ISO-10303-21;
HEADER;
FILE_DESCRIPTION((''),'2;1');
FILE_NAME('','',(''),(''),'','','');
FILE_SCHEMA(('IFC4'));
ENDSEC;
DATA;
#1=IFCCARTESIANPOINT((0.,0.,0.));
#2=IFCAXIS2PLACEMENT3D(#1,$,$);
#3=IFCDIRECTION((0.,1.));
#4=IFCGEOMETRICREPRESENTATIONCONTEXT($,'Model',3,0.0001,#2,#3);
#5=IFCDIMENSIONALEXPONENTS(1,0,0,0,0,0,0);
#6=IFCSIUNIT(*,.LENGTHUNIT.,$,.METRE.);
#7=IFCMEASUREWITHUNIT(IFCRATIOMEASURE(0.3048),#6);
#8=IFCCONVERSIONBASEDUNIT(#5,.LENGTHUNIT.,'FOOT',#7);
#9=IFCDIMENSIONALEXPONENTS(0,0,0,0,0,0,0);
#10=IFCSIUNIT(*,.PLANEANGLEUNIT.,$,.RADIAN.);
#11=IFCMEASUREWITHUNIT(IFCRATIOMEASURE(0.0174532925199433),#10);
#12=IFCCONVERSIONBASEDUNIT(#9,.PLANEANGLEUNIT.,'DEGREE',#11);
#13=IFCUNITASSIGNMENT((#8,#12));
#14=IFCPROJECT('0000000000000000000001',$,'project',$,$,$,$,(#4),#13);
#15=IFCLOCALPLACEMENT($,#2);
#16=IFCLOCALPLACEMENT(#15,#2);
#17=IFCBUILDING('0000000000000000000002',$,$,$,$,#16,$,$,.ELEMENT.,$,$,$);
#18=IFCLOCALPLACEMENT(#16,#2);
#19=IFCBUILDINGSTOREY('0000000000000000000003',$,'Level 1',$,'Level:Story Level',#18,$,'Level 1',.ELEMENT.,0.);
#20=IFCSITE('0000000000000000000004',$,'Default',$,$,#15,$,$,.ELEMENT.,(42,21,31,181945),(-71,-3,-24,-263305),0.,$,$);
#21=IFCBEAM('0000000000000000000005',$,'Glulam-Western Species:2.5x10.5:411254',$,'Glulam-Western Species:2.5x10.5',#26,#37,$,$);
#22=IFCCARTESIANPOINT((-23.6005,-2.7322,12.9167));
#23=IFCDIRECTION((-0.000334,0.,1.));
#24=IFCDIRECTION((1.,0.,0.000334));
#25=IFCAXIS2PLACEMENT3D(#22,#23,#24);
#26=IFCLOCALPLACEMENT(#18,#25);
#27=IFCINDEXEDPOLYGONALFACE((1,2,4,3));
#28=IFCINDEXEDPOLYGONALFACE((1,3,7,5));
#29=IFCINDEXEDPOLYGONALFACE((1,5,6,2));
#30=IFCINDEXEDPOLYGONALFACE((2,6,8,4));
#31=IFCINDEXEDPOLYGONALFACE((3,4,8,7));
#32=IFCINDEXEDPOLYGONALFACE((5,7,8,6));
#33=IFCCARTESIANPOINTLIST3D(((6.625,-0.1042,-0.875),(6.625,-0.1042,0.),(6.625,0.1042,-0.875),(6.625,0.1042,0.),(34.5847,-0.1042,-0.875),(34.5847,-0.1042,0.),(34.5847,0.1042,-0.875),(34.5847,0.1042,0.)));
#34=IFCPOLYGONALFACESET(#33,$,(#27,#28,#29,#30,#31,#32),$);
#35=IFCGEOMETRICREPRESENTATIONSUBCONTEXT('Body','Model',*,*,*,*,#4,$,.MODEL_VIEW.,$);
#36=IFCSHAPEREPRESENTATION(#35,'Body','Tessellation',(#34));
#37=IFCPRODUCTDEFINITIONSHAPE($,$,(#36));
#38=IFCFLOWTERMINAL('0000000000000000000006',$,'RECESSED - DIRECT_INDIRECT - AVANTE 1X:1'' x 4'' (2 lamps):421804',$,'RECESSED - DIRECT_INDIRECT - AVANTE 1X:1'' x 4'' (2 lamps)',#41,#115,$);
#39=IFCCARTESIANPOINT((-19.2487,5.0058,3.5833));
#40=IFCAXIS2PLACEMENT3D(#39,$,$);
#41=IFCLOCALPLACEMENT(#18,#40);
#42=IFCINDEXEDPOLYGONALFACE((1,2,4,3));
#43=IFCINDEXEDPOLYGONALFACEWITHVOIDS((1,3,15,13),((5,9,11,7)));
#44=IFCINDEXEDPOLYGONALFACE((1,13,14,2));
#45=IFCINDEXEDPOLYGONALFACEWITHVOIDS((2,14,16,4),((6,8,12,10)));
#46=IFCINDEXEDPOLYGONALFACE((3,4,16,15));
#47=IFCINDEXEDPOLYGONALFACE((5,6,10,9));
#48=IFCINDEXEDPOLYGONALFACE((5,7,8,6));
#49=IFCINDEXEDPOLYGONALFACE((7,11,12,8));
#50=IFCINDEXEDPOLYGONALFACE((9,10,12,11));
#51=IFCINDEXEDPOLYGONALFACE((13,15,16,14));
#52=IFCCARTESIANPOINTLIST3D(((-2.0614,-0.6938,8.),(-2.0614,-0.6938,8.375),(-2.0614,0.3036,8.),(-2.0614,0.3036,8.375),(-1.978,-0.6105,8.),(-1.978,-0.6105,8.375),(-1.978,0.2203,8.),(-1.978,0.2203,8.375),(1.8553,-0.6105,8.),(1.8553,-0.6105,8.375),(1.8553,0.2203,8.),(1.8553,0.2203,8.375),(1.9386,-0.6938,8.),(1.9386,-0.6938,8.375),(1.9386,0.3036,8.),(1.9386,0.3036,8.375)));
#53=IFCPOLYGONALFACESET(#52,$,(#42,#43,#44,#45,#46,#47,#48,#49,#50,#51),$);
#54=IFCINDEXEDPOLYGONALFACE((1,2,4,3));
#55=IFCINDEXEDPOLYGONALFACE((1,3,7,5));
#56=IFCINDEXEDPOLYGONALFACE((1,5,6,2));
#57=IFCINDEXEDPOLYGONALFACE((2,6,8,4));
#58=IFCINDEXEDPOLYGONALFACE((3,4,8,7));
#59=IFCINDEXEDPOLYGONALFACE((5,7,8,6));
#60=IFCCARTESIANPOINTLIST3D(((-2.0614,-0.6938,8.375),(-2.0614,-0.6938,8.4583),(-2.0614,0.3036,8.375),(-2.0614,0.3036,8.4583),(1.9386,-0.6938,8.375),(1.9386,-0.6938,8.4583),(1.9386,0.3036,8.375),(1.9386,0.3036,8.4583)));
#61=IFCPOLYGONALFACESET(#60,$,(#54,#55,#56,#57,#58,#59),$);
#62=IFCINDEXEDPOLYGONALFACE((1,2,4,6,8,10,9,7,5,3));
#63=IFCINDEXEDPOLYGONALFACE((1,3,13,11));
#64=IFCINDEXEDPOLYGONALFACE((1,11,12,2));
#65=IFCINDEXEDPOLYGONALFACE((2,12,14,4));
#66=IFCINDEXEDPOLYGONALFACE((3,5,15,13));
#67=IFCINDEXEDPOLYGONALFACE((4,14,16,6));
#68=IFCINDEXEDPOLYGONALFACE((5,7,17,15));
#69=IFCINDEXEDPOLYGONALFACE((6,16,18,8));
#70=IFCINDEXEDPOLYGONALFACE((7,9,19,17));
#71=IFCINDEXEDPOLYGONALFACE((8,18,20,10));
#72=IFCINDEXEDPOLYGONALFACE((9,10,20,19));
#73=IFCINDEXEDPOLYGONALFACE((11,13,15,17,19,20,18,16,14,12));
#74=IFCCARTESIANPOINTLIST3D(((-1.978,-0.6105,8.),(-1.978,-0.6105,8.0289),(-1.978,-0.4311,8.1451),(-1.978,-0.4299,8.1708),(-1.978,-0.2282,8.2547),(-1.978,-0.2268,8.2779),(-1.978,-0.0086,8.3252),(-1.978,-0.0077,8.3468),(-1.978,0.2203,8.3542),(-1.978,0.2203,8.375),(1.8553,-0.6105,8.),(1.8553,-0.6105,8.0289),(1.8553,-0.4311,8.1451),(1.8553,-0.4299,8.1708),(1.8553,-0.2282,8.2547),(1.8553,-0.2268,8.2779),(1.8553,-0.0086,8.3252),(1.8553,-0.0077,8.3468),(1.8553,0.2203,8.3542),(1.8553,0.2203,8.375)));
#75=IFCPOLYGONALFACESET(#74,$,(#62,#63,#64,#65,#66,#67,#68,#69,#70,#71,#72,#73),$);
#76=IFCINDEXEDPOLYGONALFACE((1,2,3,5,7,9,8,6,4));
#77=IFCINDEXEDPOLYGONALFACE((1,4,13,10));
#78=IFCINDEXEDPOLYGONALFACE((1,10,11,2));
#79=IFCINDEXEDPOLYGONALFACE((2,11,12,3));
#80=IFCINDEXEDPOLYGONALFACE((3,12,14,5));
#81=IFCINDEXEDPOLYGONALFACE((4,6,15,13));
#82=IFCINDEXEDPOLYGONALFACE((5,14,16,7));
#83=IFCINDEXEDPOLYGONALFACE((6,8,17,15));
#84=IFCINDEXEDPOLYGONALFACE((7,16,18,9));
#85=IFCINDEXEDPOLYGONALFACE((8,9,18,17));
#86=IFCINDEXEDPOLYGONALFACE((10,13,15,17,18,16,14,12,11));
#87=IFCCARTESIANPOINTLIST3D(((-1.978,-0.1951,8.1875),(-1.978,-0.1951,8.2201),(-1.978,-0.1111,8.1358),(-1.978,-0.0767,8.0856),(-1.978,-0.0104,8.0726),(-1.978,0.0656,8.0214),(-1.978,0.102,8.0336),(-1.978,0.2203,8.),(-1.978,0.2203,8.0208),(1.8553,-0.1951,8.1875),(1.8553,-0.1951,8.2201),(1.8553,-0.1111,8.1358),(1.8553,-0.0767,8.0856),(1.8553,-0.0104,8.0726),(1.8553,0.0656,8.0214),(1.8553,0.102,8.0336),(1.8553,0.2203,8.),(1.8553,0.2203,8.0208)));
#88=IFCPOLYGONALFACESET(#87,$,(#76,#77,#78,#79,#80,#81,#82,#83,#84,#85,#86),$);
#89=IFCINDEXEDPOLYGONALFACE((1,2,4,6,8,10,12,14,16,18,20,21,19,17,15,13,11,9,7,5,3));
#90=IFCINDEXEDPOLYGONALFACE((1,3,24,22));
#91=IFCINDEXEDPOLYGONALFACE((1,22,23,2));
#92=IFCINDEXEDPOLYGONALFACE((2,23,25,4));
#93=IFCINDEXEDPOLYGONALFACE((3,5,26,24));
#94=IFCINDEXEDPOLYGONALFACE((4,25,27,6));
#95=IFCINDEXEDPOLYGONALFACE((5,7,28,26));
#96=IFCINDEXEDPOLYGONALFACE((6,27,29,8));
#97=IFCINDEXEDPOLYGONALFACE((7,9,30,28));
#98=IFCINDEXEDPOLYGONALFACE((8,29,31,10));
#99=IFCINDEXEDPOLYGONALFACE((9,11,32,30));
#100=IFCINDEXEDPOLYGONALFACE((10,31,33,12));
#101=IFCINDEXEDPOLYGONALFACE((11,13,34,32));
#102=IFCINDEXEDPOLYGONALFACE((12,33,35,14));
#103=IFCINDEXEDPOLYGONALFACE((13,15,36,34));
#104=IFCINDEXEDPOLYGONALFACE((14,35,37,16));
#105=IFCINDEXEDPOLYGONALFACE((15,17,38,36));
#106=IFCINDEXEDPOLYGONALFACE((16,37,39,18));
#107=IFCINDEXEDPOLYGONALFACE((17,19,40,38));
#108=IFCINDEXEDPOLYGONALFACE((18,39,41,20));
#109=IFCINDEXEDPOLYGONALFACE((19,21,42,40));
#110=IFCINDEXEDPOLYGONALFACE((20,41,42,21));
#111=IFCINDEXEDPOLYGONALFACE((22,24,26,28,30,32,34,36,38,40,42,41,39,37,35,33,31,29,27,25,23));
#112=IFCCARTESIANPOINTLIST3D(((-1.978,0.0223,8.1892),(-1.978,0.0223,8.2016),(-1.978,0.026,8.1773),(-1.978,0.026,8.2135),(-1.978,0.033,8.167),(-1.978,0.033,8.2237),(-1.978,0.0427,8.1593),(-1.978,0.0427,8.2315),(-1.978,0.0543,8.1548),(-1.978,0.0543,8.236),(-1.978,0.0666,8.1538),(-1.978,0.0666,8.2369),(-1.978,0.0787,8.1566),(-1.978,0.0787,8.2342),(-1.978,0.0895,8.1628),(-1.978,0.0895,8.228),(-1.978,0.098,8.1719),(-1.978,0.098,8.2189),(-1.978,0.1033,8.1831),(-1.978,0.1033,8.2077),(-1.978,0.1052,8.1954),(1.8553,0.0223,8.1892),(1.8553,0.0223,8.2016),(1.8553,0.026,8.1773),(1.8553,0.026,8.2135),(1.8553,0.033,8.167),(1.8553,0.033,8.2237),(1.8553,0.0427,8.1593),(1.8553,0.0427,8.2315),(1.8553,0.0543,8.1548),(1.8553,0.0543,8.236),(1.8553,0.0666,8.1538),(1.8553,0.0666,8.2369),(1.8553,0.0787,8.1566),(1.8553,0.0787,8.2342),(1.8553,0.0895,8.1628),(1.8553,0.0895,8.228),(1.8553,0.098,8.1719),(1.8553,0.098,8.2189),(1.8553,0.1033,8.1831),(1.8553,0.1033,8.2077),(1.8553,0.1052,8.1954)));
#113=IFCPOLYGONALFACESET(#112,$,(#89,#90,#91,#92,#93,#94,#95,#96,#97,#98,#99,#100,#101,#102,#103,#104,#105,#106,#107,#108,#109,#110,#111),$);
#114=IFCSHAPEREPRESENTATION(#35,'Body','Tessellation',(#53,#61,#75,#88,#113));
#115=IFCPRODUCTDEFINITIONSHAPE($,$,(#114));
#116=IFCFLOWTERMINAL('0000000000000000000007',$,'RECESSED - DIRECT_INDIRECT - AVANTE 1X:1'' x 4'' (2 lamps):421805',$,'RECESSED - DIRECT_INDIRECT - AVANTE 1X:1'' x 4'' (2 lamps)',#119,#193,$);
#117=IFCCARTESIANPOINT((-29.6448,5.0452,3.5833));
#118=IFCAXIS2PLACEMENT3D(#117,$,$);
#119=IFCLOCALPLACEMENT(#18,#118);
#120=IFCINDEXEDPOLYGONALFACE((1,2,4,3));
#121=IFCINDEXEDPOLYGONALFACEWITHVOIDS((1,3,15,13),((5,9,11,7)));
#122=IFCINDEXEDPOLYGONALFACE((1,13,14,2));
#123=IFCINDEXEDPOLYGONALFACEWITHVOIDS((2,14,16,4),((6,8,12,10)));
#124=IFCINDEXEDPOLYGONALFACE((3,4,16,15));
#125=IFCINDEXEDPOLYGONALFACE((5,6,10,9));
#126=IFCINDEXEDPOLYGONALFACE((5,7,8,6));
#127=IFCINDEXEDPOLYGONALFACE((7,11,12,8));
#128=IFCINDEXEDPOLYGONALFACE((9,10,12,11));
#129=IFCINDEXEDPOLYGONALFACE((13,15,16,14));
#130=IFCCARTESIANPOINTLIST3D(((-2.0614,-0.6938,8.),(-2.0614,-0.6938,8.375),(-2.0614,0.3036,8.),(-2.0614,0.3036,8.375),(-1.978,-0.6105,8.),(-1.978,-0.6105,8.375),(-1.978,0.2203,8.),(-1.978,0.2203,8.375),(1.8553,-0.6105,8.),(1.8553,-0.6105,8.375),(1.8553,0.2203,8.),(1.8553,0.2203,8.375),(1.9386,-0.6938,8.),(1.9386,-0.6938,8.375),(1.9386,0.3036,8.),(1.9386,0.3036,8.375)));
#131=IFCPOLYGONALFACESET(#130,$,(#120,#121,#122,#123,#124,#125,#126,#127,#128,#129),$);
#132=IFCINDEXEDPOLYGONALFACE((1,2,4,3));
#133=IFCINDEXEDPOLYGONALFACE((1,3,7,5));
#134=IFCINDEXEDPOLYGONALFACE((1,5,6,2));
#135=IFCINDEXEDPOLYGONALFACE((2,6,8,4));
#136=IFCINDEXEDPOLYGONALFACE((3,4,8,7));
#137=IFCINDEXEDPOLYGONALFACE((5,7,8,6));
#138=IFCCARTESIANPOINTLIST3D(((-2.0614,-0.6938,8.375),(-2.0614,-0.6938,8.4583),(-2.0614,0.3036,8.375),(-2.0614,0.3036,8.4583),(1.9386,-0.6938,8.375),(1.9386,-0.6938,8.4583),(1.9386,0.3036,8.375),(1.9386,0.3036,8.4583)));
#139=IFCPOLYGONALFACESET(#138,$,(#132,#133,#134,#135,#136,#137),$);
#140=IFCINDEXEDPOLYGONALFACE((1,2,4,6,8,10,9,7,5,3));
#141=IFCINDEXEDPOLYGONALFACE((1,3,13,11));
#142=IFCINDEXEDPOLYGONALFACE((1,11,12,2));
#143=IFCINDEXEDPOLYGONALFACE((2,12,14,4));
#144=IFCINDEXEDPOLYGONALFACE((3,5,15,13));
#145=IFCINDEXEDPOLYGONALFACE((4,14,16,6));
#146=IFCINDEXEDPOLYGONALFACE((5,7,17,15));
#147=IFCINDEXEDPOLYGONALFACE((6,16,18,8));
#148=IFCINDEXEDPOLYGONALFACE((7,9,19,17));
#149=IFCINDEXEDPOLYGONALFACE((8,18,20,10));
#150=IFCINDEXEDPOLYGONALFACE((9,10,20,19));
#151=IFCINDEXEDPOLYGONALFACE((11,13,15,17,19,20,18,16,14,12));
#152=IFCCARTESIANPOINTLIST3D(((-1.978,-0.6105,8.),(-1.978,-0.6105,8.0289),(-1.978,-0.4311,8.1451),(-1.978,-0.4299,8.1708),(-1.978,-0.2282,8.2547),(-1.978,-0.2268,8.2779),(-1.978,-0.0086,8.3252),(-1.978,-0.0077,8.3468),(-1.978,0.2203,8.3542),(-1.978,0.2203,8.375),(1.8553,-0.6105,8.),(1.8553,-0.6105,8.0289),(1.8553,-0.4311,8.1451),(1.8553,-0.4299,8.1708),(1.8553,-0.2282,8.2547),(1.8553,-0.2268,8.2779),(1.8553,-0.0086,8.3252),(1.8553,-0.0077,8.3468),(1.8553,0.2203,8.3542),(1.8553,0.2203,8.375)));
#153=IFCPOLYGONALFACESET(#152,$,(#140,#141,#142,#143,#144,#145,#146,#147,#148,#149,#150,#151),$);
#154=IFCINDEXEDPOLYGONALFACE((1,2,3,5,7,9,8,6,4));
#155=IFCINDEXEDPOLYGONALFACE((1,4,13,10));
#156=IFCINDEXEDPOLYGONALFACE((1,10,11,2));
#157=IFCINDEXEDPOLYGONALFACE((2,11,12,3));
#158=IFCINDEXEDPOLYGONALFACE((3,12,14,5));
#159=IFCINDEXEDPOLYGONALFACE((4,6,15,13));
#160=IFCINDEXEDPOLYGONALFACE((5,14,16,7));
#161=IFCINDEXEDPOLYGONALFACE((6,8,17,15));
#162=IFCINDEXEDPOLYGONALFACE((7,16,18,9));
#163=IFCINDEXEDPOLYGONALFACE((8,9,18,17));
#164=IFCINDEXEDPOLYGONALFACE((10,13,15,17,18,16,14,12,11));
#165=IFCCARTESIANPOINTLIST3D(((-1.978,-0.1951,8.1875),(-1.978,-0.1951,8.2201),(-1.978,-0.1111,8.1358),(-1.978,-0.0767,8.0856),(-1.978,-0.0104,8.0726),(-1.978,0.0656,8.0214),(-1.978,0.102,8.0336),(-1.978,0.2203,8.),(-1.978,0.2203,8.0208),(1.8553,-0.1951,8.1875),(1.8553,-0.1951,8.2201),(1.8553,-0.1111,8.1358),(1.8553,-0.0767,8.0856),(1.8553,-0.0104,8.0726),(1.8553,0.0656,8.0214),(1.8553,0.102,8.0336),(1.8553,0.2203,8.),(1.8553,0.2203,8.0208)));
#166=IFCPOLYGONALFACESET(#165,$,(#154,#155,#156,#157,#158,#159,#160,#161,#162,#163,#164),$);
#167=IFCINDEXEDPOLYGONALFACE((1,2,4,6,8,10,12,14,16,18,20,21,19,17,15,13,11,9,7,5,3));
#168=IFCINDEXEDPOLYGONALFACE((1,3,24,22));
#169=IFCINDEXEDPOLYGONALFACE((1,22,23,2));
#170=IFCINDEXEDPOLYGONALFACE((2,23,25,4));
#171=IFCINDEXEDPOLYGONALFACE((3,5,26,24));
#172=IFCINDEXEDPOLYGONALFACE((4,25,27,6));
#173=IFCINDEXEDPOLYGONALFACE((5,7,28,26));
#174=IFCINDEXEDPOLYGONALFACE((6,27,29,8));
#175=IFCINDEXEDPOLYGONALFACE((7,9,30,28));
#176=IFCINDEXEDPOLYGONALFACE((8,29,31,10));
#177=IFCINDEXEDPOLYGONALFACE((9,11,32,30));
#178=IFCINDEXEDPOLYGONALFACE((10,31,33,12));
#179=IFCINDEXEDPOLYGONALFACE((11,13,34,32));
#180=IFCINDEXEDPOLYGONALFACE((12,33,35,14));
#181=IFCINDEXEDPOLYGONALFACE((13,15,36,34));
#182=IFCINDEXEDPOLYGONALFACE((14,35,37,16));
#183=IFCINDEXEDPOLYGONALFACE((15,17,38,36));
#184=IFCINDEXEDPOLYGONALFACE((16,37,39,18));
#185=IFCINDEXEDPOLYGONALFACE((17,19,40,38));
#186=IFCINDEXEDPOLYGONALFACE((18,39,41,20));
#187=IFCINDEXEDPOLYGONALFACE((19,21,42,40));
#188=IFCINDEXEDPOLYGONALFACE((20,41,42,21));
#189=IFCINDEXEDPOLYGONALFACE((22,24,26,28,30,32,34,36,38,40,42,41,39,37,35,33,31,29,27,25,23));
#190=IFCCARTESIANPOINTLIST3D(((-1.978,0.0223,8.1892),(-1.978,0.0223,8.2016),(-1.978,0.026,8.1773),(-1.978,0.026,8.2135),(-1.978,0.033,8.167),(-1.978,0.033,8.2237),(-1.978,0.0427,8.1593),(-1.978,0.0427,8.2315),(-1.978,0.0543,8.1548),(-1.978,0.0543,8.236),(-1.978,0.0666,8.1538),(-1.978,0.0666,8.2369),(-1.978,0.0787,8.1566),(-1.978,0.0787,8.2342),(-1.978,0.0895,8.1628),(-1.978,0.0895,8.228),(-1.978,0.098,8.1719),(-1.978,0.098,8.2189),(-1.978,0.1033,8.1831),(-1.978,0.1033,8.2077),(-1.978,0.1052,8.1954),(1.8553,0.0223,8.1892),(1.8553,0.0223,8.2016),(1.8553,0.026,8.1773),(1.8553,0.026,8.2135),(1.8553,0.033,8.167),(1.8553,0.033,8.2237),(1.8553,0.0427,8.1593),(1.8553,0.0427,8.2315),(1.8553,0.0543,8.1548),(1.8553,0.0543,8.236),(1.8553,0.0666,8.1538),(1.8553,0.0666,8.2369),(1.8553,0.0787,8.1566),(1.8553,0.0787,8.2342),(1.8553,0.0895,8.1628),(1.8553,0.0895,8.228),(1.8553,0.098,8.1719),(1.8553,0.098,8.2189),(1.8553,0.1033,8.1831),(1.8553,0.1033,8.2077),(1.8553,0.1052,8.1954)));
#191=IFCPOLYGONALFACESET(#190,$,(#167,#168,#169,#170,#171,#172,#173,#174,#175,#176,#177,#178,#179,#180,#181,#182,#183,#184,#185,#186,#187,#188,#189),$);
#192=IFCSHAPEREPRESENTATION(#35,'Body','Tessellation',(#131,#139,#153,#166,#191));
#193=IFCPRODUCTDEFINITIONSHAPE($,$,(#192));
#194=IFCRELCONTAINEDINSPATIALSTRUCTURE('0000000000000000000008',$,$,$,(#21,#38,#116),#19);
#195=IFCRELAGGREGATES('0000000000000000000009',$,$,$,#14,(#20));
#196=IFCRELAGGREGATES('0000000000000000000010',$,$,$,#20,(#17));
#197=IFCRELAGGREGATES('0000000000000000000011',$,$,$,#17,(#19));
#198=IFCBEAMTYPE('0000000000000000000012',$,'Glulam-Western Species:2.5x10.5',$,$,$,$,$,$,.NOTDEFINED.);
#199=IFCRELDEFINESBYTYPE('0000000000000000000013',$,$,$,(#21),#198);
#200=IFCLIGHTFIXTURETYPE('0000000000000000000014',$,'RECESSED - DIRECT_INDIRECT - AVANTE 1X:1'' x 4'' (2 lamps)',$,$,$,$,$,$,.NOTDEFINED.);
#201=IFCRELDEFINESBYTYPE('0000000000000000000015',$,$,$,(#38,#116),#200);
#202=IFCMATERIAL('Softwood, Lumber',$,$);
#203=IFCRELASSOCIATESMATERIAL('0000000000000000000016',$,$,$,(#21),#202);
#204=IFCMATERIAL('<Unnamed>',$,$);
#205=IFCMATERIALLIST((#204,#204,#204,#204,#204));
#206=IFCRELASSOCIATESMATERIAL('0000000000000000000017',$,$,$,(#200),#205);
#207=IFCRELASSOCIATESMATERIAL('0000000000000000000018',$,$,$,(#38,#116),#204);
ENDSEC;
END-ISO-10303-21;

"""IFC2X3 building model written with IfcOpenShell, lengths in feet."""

from ifc_helpers import new_model, entity, si_unit, converted_unit, direction, frame, frame_2d, origin, origin_2d_with_axis, place, context, subcontext, project, spatial, polyline, circle_curve, parameter, trimmed, segment, composite_curve, rectangle, circle, outline, extrude, source, transform, mapped, material, material_list, type_object, type_shapes, element, save


model = new_model("IFC2X3")

# Units and contexts
model_context = context("Model", 3, precision=0.0001, world=origin(), true_north=direction((0.0, 1.0)))
body_context = subcontext(model_context, "Body", "Model", "MODEL_VIEW")
ifc_project = project(units=[converted_unit("LENGTHUNIT", "FOOT", entity("IfcRatioMeasure", 0.3048), si_unit("LENGTHUNIT", "METRE"), dimensions=[1, 0, 0, 0, 0, 0, 0]), converted_unit("PLANEANGLEUNIT", "DEGREE", entity("IfcRatioMeasure", 0.0174532925199433), si_unit("PLANEANGLEUNIT", "RADIAN"), dimensions=[0, 0, 0, 0, 0, 0, 0])], contexts=[model_context])

# Site, building, storey
site_placement = place(None, origin())
site = spatial("IfcSite", under=ifc_project, at=site_placement, Name="Default", CompositionType="ELEMENT", RefLatitude=(42, 21, 31, 181945), RefLongitude=(-71, -3, -24, -263305), RefElevation=0.0)
building_placement = place(site_placement, origin())
building = spatial("IfcBuilding", under=site, at=building_placement, CompositionType="ELEMENT")
storey_placement = place(building_placement, origin())
storey = spatial("IfcBuildingStorey", under=building, at=storey_placement, Name="Level 1", ObjectType="Level:Story Level", LongName="Level 1", CompositionType="ELEMENT", Elevation=0.0)

# Beam
ifc_material_1 = material(Name="Softwood, Lumber")
beam_type = type_object("IfcBeamType", Name="Glulam-Western Species:2.5x10.5", PredefinedType="NOTDEFINED")
beam_1_placement = place(storey_placement, frame((-23.6005, -2.7322, 12.9167), z_axis=(-0.000334, 0.0, 1.0), x_axis=(1.0, 0.0, 0.000334)))
element("IfcBeam", 1, at=beam_1_placement, inside=storey, type_object=beam_type, material=ifc_material_1, Name="Glulam-Western Species:2.5x10.5:411254", ObjectType="Glulam-Western Species:2.5x10.5", context=body_context, shape_type="SweptSolid", body=[
    extrude(rectangle(XDim=0.875, YDim=0.2083, at=frame_2d((0.0, 0.0), x_axis=(1.0, 0.0))), frame((6.625, 0.0, -0.4375), z_axis=(1.0, 0.0, 0.0), x_axis=(0.0, 0.0, -1.0)), (0.0, 0.0, 1.0), 27.9597),
])

# Flow terminals
ifc_material_2 = material(Name="<Unnamed>")
ifc_material_list_1 = material_list([ifc_material_2, ifc_material_2, ifc_material_2, ifc_material_2, ifc_material_2])
light_fixture_type = type_object("IfcLightFixtureType", Name="RECESSED - DIRECT_INDIRECT - AVANTE 1X:1' x 4' (2 lamps)", PredefinedType="NOTDEFINED", material=ifc_material_list_1)
shared_shape_1 = source(origin(), body_context, "Body", "SweptSolid", [
    extrude(outline(polyline([(-2.0, -0.4987), (2.0, -0.4987), (2.0, 0.4987), (-2.0, 0.4987), (-2.0, -0.4987)]), holes=[polyline([(-1.9167, -0.4154), (-1.9167, 0.4154), (1.9167, 0.4154), (1.9167, -0.4154), (-1.9167, -0.4154)])]), frame((-0.0614, -0.1951, 8.0), z_axis=(0.0, 0.0, 1.0), x_axis=(-1.0, 0.0, 0.0)), (0.0, 0.0, 1.0), 0.375),
    extrude(rectangle(XDim=4.0, YDim=0.9974, at=origin_2d_with_axis()), frame((-0.0614, -0.1951, 8.375), z_axis=(0.0, 0.0, 1.0), x_axis=(-1.0, 0.0, 0.0)), (0.0, 0.0, 1.0), 0.0833),
    extrude(outline(composite_curve([segment(trimmed(circle_curve(frame_2d((-1.0846, 0.4571), x_axis=(-1.0, 0.0)), 1.25), [parameter(135.734122)], [parameter(178.085644)], True, "PARAMETER"), False, "CONTINUOUS"), segment(polyline([(-0.1895, -0.4154), (-0.1606, -0.4154)]), True, "CONTINUOUS"), segment(trimmed(circle_curve(frame_2d((-1.0846, 0.4571), x_axis=(-1.0, 0.0)), 1.2708), [parameter(136.642648)], [parameter(178.117038)], True, "PARAMETER"), True, "CONTINUOUS"), segment(polyline([(0.1855, 0.4154), (0.1647, 0.4154)]), True, "CONTINUOUS")], self_intersect=False)), frame((-1.978, -0.1951, 8.1895), z_axis=(-1.0, 0.0, 0.0), x_axis=(0.0, 0.0, 1.0)), (0.0, 0.0, -1.0), 3.8333),
    extrude(outline(composite_curve([segment(polyline([(0.0863, -0.2077), (0.1071, -0.2077)]), True, "CONTINUOUS"), segment(trimmed(circle_curve(frame_2d((-0.4397, -0.2045), x_axis=(1.0, 0.0)), 0.5468), [parameter(359.668292)], [parameter(48.921556)], True, "PARAMETER"), True, "CONTINUOUS"), segment(polyline([(-0.0804, 0.2077), (-0.113, 0.2077)]), True, "CONTINUOUS"), segment(trimmed(circle_curve(frame_2d((-0.4397, -0.2045), x_axis=(1.0, 0.0)), 0.526), [parameter(359.655153)], [parameter(51.59762)], True, "PARAMETER"), False, "CONTINUOUS")], self_intersect=False)), frame((-1.978, 0.0126, 8.1071), z_axis=(-1.0, 0.0, 0.0), x_axis=(0.0, 0.0, -1.0)), (0.0, 0.0, -1.0), 3.8333),
    extrude(circle(Radius=0.0417, at=origin_2d_with_axis()), frame((-1.978, 0.0635, 8.1954), z_axis=(1.0, 0.0, 0.0), x_axis=(0.0, 1.0, 0.0)), (0.0, 0.0, 1.0), 3.8333),
])
type_shapes(light_fixture_type, [shared_shape_1])
for number, where, name in (
    (2, (-19.2487, 5.0058, 3.5833), "RECESSED - DIRECT_INDIRECT - AVANTE 1X:1' x 4' (2 lamps):421804"),
    (3, (-29.6448, 5.0452, 3.5833), "RECESSED - DIRECT_INDIRECT - AVANTE 1X:1' x 4' (2 lamps):421805"),
):
    element("IfcFlowTerminal", number, at=place(storey_placement, frame(where)), inside=storey, type_object=light_fixture_type, material=ifc_material_2, Name=name, ObjectType="RECESSED - DIRECT_INDIRECT - AVANTE 1X:1' x 4' (2 lamps)", context=body_context, shape_type="MappedRepresentation", body=[
        mapped(shared_shape_1, transform((0.0, 0.0, 0.0), scale=1.0)),
    ])

save(model, "model.ifc")
